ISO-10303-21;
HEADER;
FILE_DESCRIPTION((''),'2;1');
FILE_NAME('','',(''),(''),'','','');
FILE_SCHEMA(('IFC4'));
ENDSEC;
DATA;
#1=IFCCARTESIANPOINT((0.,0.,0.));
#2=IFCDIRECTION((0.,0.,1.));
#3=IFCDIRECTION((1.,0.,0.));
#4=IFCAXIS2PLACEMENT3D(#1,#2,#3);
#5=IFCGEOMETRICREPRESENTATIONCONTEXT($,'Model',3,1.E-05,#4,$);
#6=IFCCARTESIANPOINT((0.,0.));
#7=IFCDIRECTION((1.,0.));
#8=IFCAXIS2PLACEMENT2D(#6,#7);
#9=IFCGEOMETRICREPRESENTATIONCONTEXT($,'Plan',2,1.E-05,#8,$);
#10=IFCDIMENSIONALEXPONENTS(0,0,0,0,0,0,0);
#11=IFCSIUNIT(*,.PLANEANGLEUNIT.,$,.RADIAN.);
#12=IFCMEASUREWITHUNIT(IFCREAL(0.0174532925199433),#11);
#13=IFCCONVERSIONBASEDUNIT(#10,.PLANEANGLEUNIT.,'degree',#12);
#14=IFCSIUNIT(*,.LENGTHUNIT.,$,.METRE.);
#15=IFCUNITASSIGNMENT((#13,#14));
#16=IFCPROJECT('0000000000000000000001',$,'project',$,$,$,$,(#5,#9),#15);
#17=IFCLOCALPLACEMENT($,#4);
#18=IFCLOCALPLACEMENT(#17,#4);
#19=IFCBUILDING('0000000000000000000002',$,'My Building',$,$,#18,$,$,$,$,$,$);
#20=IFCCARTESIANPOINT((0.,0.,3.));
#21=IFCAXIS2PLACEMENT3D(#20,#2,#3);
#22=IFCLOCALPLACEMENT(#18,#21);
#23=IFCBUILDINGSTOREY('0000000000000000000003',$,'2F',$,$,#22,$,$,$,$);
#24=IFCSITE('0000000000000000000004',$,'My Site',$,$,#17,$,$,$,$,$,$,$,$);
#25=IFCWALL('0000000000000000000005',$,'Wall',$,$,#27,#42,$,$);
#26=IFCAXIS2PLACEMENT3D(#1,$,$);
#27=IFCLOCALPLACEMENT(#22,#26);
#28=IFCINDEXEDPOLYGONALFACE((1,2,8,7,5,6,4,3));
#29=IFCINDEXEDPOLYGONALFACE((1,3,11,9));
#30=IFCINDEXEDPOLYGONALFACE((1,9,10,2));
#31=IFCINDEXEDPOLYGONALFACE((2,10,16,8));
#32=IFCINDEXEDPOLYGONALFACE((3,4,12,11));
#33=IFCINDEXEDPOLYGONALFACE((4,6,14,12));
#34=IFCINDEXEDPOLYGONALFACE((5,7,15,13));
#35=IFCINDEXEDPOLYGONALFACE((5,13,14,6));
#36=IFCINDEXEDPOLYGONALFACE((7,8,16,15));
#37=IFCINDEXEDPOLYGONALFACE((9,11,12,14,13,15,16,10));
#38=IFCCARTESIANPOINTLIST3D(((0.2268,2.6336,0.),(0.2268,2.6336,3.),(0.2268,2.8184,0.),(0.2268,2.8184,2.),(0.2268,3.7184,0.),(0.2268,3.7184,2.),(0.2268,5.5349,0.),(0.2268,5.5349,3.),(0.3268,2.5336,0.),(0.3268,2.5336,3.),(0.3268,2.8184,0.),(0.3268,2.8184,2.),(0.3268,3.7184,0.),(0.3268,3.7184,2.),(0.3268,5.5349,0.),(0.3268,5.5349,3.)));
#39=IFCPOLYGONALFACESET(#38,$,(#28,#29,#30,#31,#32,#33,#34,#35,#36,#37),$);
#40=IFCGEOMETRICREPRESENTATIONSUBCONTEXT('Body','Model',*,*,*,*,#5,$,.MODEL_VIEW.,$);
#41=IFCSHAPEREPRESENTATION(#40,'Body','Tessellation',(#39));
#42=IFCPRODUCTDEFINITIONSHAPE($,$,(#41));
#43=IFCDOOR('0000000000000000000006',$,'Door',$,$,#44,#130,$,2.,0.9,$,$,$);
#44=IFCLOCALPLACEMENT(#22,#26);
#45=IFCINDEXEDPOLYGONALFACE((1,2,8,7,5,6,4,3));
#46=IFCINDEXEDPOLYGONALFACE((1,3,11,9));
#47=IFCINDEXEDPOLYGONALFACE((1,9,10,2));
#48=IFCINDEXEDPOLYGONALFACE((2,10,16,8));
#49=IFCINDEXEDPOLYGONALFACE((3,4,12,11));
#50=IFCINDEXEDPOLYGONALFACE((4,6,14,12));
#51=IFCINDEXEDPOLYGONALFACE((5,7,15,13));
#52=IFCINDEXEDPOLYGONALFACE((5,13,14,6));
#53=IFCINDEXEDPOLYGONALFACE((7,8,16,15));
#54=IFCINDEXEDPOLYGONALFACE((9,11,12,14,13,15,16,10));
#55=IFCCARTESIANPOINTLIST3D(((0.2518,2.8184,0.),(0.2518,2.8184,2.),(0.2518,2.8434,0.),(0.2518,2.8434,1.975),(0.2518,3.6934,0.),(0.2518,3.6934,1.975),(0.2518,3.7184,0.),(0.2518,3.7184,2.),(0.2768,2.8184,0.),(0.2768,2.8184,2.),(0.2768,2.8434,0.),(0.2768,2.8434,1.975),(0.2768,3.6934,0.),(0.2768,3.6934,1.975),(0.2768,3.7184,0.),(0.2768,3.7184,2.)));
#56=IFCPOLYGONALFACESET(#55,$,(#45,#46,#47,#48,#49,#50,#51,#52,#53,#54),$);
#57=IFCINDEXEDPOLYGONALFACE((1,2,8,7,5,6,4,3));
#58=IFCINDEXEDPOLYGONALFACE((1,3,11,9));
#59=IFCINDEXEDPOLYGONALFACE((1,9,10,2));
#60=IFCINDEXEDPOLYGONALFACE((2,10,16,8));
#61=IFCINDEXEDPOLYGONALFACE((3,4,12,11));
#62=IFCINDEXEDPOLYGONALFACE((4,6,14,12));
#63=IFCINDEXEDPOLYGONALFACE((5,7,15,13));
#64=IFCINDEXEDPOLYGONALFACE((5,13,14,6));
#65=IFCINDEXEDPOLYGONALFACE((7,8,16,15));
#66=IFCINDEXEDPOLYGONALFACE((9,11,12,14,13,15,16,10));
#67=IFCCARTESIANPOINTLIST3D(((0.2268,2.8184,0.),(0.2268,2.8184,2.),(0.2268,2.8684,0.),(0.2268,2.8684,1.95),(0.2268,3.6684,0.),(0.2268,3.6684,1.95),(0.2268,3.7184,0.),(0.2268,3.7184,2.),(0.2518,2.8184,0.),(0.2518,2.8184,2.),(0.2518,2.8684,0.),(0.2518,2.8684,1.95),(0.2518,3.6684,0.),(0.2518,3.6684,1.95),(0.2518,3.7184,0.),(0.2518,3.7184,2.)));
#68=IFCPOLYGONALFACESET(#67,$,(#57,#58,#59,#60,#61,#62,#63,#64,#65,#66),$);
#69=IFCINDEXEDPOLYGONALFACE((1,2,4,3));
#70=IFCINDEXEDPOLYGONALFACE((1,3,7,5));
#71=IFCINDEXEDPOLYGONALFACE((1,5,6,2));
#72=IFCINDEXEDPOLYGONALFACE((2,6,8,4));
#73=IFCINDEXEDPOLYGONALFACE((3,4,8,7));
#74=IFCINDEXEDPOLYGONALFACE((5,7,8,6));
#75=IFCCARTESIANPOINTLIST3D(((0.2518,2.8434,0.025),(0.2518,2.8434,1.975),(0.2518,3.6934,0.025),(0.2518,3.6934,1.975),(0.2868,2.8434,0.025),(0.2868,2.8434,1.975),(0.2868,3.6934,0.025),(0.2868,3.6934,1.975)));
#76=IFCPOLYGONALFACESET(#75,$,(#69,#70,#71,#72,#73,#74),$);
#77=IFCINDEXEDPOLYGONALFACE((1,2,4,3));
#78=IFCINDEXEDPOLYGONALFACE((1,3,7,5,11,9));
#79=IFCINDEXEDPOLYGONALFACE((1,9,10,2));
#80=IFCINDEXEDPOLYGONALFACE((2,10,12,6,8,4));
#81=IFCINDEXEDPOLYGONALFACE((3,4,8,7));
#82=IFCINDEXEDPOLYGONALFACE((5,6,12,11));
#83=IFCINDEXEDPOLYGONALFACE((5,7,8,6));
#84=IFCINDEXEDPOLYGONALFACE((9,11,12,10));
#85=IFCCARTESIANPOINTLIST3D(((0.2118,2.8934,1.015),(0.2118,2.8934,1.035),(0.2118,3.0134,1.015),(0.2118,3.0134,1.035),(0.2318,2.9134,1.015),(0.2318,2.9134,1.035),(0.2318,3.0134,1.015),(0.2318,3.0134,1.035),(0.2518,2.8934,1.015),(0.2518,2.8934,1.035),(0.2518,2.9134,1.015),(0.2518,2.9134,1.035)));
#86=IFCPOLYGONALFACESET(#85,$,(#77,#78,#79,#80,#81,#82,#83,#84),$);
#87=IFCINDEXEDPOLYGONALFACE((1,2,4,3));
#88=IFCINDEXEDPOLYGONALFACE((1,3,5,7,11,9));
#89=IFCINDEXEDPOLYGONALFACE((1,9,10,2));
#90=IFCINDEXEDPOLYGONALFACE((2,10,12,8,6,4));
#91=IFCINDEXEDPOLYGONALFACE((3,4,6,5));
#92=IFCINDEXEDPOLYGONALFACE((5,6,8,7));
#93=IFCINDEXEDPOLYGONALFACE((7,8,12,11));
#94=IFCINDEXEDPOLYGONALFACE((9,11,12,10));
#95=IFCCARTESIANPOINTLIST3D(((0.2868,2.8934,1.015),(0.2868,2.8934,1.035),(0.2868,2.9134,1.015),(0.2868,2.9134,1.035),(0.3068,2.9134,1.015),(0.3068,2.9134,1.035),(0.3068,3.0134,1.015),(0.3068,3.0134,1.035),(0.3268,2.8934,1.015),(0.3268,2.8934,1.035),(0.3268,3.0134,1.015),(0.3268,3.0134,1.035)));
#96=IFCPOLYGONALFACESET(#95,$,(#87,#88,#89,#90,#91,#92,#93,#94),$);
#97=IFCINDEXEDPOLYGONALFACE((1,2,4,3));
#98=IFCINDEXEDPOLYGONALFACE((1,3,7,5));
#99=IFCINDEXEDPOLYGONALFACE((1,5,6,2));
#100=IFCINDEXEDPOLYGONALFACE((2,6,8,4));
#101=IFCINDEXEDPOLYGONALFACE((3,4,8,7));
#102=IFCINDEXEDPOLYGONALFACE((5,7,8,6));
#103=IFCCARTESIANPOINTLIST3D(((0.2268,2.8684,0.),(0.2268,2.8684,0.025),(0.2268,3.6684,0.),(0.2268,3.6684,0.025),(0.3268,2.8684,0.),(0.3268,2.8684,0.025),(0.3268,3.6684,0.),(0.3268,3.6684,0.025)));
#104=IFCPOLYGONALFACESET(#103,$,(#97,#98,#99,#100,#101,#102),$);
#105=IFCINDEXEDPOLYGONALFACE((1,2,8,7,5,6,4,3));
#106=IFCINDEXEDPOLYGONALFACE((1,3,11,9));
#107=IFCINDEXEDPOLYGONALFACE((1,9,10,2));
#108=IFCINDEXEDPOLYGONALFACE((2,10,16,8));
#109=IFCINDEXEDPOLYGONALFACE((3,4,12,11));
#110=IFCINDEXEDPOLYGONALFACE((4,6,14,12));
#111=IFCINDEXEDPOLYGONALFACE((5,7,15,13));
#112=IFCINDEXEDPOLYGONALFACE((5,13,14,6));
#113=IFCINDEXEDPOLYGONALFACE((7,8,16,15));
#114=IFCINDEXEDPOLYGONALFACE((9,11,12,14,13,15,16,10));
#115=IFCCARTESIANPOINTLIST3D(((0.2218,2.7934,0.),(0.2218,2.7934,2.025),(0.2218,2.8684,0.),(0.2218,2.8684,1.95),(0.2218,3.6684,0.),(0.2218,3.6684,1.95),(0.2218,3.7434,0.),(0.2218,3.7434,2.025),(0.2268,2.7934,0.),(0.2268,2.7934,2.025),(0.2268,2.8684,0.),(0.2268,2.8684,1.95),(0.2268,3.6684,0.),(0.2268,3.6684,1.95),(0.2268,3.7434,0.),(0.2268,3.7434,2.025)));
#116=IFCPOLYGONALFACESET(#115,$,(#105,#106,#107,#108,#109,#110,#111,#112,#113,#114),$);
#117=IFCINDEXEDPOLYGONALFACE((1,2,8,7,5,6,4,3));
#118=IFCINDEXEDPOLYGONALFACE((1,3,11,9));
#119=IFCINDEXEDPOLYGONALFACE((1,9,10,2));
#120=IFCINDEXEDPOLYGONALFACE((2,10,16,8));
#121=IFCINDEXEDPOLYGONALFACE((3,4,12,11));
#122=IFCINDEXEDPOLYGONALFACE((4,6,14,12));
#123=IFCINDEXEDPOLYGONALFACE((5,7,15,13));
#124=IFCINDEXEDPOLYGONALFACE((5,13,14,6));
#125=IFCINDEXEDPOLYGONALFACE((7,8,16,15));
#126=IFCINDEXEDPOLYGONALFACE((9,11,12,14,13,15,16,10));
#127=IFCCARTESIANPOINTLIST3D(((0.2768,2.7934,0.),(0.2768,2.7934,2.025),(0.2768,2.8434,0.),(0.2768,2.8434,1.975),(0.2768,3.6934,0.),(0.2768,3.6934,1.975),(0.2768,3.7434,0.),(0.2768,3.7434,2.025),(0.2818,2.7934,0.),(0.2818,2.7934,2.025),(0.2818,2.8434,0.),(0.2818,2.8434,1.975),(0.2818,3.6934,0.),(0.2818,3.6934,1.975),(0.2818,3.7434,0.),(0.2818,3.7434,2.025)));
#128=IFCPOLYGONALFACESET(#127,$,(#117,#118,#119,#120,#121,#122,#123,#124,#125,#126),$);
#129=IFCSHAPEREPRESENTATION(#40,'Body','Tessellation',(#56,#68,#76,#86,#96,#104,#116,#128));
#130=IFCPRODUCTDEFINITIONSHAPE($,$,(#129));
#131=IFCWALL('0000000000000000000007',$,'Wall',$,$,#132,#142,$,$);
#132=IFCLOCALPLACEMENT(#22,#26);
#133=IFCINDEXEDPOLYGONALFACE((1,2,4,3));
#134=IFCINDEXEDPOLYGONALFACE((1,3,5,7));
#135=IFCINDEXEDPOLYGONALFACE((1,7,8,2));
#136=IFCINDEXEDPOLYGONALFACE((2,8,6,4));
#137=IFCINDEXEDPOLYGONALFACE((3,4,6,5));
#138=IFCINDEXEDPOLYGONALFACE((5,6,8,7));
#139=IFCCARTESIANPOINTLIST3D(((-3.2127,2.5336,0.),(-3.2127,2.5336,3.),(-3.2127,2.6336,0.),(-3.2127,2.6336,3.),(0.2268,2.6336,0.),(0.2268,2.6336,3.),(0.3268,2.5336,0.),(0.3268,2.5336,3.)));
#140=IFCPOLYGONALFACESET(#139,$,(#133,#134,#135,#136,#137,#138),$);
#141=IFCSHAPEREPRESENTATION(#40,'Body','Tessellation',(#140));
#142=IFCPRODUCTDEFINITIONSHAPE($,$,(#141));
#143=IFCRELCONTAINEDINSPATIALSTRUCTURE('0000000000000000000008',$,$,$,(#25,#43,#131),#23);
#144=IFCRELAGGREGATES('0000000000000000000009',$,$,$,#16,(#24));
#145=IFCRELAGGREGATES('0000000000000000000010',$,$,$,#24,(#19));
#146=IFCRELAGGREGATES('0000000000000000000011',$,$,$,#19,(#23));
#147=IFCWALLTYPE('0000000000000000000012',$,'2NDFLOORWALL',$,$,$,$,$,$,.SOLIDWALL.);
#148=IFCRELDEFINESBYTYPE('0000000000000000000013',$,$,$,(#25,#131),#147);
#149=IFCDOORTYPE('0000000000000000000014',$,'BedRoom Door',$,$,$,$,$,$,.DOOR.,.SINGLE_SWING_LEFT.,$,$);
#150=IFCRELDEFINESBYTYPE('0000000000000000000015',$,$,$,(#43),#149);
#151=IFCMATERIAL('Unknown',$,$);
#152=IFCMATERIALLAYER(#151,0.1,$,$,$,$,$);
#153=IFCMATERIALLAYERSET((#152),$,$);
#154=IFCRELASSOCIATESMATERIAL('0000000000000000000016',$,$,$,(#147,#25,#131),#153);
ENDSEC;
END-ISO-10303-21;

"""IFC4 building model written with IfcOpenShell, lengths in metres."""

from ifc_helpers import new_model, entity, si_unit, converted_unit, frame, origin_with_axes, origin_2d_with_axis, place, context, subcontext, project, spatial, line, indexed_curve, outline, extrude, shape, source, transform, mapped, material, layer, layer_set, layer_usage, type_object, type_shapes, element, fill, save


model = new_model("IFC4")

# Units and contexts
model_context = context("Model", 3, precision=1e-05, world=origin_with_axes())
plan_context = context("Plan", 2, precision=1e-05, world=origin_2d_with_axis())
body_context_1 = subcontext(model_context, "Body", "Model", "MODEL_VIEW")
body_context_2 = subcontext(plan_context, "Body", "Plan", "PLAN_VIEW")
ifc_project = project(units=[converted_unit("PLANEANGLEUNIT", "degree", entity("IfcReal", 0.0174532925199433), si_unit("PLANEANGLEUNIT", "RADIAN"), dimensions=[0, 0, 0, 0, 0, 0, 0]), si_unit("LENGTHUNIT", "METRE")], contexts=[model_context, plan_context])

# Site, building, storey
site_placement = place(None, origin_with_axes())
site = spatial("IfcSite", under=ifc_project, at=site_placement, Name="My Site")
building_placement = place(site_placement, origin_with_axes())
building = spatial("IfcBuilding", under=site, at=building_placement, Name="My Building")
storey_placement = place(building_placement, frame((0.0, 0.0, 3.0), z_axis=(0.0, 0.0, 1.0), x_axis=(1.0, 0.0, 0.0)))
storey = spatial("IfcBuildingStorey", under=building, at=storey_placement, Name="2F")

# Shared definitions
ifc_material = material(Name="Unknown")

# Shared definitions
ifc_layer_1 = layer(ifc_material, 0.1)
ifc_layer_set_1 = layer_set([ifc_layer_1])
wall_type_1 = type_object("IfcWallType", Name="2NDFLOORWALL", PredefinedType="SOLIDWALL", material=ifc_layer_set_1)

# Wall, opening, door
ifc_layer_usage_1 = layer_usage(ifc_layer_set_1, "AXIS2", "POSITIVE", 0.0)
wall_1_placement = place(storey_placement, frame((0.2268, 5.5349, 0.0), z_axis=(0.0, 0.0, 1.0), x_axis=(0.0, -1.0, 0.0)))
wall_1 = element("IfcWall", 1, at=wall_1_placement, inside=storey, type_object=wall_type_1, material=ifc_layer_usage_1, Name="Wall", context=body_context_1, shape_type="SweptSolid", body=[
    extrude(outline(indexed_curve([(0.0, 0.0), (0.0, 0.1), (3.0013, 0.1), (2.9013, 0.0)], segments=[line(1, 2, 3, 4, 1)])), origin_with_axes(), (0.0, 0.0, 1.0), 3.0),
])
shared_shape_1 = source(origin_with_axes(), body_context_1, "Body", "SweptSolid", [
    extrude(outline(indexed_curve([(0.0, 0.0), (0.9, 0.0), (0.9, 2.0), (0.0, 2.0)], segments=[line(1, 2, 3, 4, 1)])), frame((0.0, -0.6, 0.0), z_axis=(0.0, -1.0, 0.0), x_axis=(1.0, 0.0, 0.0)), (0.0, 0.0, -1.0), 1.2),
])
opening_1_placement = place(wall_1_placement, frame((1.8165, 0.0, 0.0), z_axis=(0.0, 0.0, 1.0), x_axis=(1.0, 0.0, 0.0)))
opening_1 = element("IfcOpeningElement", 2, at=opening_1_placement, cuts=wall_1, PredefinedType="OPENING", context=body_context_1, shape_type="MappedRepresentation", body=[
    mapped(shared_shape_1, transform((0.0, 0.0, 0.0), x_axis=(1.0, 0.0, 0.0), y_axis=(0.0, 1.0, 0.0), z_axis=(0.0, 0.0, 1.0), scale=1.0)),
])
door_type_1 = type_object("IfcDoorType", Name="BedRoom Door", OperationType="SINGLE_SWING_LEFT", PredefinedType="DOOR")
shared_shape_2 = source(origin_with_axes(), body_context_1, "Body", "SweptSolid", [
    extrude(outline(indexed_curve([(0.0, 0.0), (0.0, 2.0), (0.9, 2.0), (0.9, 0.0), (0.875, 0.0), (0.875, 1.975), (0.025, 1.975), (0.025, 0.0)], segments=[line(1, 2, 3, 4, 5, 6, 7, 8, 1)])), frame((0.0, 0.025, 0.0), z_axis=(0.0, -1.0, 0.0), x_axis=(1.0, 0.0, 0.0)), (0.0, 0.0, -1.0), 0.025),
    extrude(outline(indexed_curve([(0.0, 0.0), (0.0, 2.0), (0.9, 2.0), (0.9, 0.0), (0.85, 0.0), (0.85, 1.95), (0.05, 1.95), (0.05, 0.0)], segments=[line(1, 2, 3, 4, 5, 6, 7, 8, 1)])), frame((0.0, 0.0, 0.0), z_axis=(0.0, -1.0, 0.0), x_axis=(1.0, 0.0, 0.0)), (0.0, 0.0, -1.0), 0.025),
    extrude(outline(indexed_curve([(0.0, 0.0), (0.85, 0.0), (0.85, 0.035), (0.0, 0.035)], segments=[line(1, 2, 3, 4, 1)])), frame((0.025, 0.025, 0.025), z_axis=(0.0, 0.0, 1.0), x_axis=(1.0, 0.0, 0.0)), (0.0, 0.0, 1.0), 1.95),
    extrude(outline(indexed_curve([(0.0, 0.0), (0.0, -0.04), (-0.12, -0.04), (-0.12, -0.02), (-0.02, -0.02), (-0.02, 0.0)], segments=[line(1, 2, 3, 4, 5, 6, 1)])), frame((0.825, 0.025, 1.015), z_axis=(0.0, 0.0, 1.0), x_axis=(1.0, 0.0, 0.0)), (0.0, 0.0, 1.0), 0.02),
    extrude(outline(indexed_curve([(0.0, 0.0), (0.0, 0.04), (-0.12, 0.04), (-0.12, 0.02), (-0.02, 0.02), (-0.02, 0.0)], segments=[line(1, 2, 3, 4, 5, 6, 1)])), frame((0.825, 0.06, 1.015), z_axis=(0.0, 0.0, 1.0), x_axis=(1.0, 0.0, 0.0)), (0.0, 0.0, 1.0), 0.02),
    extrude(outline(indexed_curve([(0.0, 0.0), (0.8, 0.0), (0.8, 0.1), (0.0, 0.1)], segments=[line(1, 2, 3, 4, 1)])), frame((0.05, 0.0, 0.0), z_axis=(0.0, 0.0, 1.0), x_axis=(1.0, 0.0, 0.0)), (0.0, 0.0, 1.0), 0.025),
    extrude(outline(indexed_curve([(0.0, 0.0), (0.0, 2.025), (0.95, 2.025), (0.95, 0.0), (0.875, 0.0), (0.875, 1.95), (0.075, 1.95), (0.075, 0.0)], segments=[line(1, 2, 3, 4, 5, 6, 7, 8, 1)])), frame((-0.025, -0.005, 0.0), z_axis=(0.0, -1.0, 0.0), x_axis=(1.0, 0.0, 0.0)), (0.0, 0.0, -1.0), 0.005),
    extrude(outline(indexed_curve([(0.0, 0.0), (0.0, 2.025), (0.95, 2.025), (0.95, 0.0), (0.9, 0.0), (0.9, 1.975), (0.05, 1.975), (0.05, 0.0)], segments=[line(1, 2, 3, 4, 5, 6, 7, 8, 1)])), frame((-0.025, 0.05, 0.0), z_axis=(0.0, -1.0, 0.0), x_axis=(1.0, 0.0, 0.0)), (0.0, 0.0, -1.0), 0.005),
])
shared_shape_3 = source(origin_with_axes(), body_context_2, "Body", "Curve2D", [
    entity("IfcIndexedPolyCurve", entity("IfcCartesianPointList2D", [[0.0, 0.0], [0.0, 0.05], [0.025, 0.05], [0.025, 0.025], [0.05, 0.025], [0.05, 0.0]]), [entity("IfcLineIndex", [1, 2, 3, 4, 5, 6, 1])]),
    entity("IfcIndexedPolyCurve", entity("IfcCartesianPointList2D", [[0.9, 0.0], [0.9, 0.05], [0.875, 0.05], [0.875, 0.025], [0.85, 0.025], [0.85, 0.0]]), [entity("IfcLineIndex", [1, 2, 3, 4, 5, 6, 1])]),
    entity("IfcTrimmedCurve", entity("IfcEllipse", entity("IfcAxis2Placement2D", entity("IfcCartesianPoint", [0.06, 0.05]), entity("IfcDirection", [1.0, 0.0])), 0.815, 0.85), [entity("IfcCartesianPoint", [0.875, 0.05])], [entity("IfcCartesianPoint", [0.06, 0.9])], True, "CARTESIAN"),
    entity("IfcIndexedPolyCurve", entity("IfcCartesianPointList2D", [[0.025, 0.05], [0.06, 0.05], [0.06, 0.9], [0.025, 0.9]]), [entity("IfcLineIndex", [1, 2, 3, 4, 1])]),
])
type_shapes(door_type_1, [shared_shape_2, shared_shape_3])
door_1_placement = place(opening_1_placement, frame((0.0, 0.0, 0.0), z_axis=(0.0, 0.0, 1.0), x_axis=(1.0, 0.0, 0.0)))
door_1 = element("IfcDoor", 3, at=door_1_placement, inside=storey, type_object=door_type_1, Name="Door", OverallHeight=2.0, OverallWidth=0.9, shapes=[
    shape(body_context_1, "Body", "MappedRepresentation", [mapped(shared_shape_2, transform((0.0, 0.0, 0.0), x_axis=(1.0, 0.0, 0.0), y_axis=(0.0, 1.0, 0.0), z_axis=(0.0, 0.0, 1.0), scale=1.0))]),
    shape(body_context_2, "Body", "MappedRepresentation", [mapped(shared_shape_3, transform((0.0, 0.0, 0.0), x_axis=(1.0, 0.0, 0.0), y_axis=(0.0, 1.0, 0.0), z_axis=(0.0, 0.0, 1.0), scale=1.0))]),
])
fill(opening_1, door_1)

# Wall
ifc_layer_usage_2 = layer_usage(ifc_layer_set_1, "AXIS2", "POSITIVE", 0.0)
wall_2_placement = place(storey_placement, frame((0.2268, 2.6336, 0.0), z_axis=(0.0, 0.0, 1.0), x_axis=(-1.0, 0.0, 0.0)))
element("IfcWall", 4, at=wall_2_placement, inside=storey, type_object=wall_type_1, material=ifc_layer_usage_2, Name="Wall", context=body_context_1, shape_type="SweptSolid", body=[
    extrude(outline(indexed_curve([(0.0, 0.0), (-0.1, 0.1), (3.4395, 0.1), (3.4395, 0.0)], segments=[line(1, 2, 3, 4, 1)])), origin_with_axes(), (0.0, 0.0, 1.0), 3.0),
])

save(model, "model.ifc")
